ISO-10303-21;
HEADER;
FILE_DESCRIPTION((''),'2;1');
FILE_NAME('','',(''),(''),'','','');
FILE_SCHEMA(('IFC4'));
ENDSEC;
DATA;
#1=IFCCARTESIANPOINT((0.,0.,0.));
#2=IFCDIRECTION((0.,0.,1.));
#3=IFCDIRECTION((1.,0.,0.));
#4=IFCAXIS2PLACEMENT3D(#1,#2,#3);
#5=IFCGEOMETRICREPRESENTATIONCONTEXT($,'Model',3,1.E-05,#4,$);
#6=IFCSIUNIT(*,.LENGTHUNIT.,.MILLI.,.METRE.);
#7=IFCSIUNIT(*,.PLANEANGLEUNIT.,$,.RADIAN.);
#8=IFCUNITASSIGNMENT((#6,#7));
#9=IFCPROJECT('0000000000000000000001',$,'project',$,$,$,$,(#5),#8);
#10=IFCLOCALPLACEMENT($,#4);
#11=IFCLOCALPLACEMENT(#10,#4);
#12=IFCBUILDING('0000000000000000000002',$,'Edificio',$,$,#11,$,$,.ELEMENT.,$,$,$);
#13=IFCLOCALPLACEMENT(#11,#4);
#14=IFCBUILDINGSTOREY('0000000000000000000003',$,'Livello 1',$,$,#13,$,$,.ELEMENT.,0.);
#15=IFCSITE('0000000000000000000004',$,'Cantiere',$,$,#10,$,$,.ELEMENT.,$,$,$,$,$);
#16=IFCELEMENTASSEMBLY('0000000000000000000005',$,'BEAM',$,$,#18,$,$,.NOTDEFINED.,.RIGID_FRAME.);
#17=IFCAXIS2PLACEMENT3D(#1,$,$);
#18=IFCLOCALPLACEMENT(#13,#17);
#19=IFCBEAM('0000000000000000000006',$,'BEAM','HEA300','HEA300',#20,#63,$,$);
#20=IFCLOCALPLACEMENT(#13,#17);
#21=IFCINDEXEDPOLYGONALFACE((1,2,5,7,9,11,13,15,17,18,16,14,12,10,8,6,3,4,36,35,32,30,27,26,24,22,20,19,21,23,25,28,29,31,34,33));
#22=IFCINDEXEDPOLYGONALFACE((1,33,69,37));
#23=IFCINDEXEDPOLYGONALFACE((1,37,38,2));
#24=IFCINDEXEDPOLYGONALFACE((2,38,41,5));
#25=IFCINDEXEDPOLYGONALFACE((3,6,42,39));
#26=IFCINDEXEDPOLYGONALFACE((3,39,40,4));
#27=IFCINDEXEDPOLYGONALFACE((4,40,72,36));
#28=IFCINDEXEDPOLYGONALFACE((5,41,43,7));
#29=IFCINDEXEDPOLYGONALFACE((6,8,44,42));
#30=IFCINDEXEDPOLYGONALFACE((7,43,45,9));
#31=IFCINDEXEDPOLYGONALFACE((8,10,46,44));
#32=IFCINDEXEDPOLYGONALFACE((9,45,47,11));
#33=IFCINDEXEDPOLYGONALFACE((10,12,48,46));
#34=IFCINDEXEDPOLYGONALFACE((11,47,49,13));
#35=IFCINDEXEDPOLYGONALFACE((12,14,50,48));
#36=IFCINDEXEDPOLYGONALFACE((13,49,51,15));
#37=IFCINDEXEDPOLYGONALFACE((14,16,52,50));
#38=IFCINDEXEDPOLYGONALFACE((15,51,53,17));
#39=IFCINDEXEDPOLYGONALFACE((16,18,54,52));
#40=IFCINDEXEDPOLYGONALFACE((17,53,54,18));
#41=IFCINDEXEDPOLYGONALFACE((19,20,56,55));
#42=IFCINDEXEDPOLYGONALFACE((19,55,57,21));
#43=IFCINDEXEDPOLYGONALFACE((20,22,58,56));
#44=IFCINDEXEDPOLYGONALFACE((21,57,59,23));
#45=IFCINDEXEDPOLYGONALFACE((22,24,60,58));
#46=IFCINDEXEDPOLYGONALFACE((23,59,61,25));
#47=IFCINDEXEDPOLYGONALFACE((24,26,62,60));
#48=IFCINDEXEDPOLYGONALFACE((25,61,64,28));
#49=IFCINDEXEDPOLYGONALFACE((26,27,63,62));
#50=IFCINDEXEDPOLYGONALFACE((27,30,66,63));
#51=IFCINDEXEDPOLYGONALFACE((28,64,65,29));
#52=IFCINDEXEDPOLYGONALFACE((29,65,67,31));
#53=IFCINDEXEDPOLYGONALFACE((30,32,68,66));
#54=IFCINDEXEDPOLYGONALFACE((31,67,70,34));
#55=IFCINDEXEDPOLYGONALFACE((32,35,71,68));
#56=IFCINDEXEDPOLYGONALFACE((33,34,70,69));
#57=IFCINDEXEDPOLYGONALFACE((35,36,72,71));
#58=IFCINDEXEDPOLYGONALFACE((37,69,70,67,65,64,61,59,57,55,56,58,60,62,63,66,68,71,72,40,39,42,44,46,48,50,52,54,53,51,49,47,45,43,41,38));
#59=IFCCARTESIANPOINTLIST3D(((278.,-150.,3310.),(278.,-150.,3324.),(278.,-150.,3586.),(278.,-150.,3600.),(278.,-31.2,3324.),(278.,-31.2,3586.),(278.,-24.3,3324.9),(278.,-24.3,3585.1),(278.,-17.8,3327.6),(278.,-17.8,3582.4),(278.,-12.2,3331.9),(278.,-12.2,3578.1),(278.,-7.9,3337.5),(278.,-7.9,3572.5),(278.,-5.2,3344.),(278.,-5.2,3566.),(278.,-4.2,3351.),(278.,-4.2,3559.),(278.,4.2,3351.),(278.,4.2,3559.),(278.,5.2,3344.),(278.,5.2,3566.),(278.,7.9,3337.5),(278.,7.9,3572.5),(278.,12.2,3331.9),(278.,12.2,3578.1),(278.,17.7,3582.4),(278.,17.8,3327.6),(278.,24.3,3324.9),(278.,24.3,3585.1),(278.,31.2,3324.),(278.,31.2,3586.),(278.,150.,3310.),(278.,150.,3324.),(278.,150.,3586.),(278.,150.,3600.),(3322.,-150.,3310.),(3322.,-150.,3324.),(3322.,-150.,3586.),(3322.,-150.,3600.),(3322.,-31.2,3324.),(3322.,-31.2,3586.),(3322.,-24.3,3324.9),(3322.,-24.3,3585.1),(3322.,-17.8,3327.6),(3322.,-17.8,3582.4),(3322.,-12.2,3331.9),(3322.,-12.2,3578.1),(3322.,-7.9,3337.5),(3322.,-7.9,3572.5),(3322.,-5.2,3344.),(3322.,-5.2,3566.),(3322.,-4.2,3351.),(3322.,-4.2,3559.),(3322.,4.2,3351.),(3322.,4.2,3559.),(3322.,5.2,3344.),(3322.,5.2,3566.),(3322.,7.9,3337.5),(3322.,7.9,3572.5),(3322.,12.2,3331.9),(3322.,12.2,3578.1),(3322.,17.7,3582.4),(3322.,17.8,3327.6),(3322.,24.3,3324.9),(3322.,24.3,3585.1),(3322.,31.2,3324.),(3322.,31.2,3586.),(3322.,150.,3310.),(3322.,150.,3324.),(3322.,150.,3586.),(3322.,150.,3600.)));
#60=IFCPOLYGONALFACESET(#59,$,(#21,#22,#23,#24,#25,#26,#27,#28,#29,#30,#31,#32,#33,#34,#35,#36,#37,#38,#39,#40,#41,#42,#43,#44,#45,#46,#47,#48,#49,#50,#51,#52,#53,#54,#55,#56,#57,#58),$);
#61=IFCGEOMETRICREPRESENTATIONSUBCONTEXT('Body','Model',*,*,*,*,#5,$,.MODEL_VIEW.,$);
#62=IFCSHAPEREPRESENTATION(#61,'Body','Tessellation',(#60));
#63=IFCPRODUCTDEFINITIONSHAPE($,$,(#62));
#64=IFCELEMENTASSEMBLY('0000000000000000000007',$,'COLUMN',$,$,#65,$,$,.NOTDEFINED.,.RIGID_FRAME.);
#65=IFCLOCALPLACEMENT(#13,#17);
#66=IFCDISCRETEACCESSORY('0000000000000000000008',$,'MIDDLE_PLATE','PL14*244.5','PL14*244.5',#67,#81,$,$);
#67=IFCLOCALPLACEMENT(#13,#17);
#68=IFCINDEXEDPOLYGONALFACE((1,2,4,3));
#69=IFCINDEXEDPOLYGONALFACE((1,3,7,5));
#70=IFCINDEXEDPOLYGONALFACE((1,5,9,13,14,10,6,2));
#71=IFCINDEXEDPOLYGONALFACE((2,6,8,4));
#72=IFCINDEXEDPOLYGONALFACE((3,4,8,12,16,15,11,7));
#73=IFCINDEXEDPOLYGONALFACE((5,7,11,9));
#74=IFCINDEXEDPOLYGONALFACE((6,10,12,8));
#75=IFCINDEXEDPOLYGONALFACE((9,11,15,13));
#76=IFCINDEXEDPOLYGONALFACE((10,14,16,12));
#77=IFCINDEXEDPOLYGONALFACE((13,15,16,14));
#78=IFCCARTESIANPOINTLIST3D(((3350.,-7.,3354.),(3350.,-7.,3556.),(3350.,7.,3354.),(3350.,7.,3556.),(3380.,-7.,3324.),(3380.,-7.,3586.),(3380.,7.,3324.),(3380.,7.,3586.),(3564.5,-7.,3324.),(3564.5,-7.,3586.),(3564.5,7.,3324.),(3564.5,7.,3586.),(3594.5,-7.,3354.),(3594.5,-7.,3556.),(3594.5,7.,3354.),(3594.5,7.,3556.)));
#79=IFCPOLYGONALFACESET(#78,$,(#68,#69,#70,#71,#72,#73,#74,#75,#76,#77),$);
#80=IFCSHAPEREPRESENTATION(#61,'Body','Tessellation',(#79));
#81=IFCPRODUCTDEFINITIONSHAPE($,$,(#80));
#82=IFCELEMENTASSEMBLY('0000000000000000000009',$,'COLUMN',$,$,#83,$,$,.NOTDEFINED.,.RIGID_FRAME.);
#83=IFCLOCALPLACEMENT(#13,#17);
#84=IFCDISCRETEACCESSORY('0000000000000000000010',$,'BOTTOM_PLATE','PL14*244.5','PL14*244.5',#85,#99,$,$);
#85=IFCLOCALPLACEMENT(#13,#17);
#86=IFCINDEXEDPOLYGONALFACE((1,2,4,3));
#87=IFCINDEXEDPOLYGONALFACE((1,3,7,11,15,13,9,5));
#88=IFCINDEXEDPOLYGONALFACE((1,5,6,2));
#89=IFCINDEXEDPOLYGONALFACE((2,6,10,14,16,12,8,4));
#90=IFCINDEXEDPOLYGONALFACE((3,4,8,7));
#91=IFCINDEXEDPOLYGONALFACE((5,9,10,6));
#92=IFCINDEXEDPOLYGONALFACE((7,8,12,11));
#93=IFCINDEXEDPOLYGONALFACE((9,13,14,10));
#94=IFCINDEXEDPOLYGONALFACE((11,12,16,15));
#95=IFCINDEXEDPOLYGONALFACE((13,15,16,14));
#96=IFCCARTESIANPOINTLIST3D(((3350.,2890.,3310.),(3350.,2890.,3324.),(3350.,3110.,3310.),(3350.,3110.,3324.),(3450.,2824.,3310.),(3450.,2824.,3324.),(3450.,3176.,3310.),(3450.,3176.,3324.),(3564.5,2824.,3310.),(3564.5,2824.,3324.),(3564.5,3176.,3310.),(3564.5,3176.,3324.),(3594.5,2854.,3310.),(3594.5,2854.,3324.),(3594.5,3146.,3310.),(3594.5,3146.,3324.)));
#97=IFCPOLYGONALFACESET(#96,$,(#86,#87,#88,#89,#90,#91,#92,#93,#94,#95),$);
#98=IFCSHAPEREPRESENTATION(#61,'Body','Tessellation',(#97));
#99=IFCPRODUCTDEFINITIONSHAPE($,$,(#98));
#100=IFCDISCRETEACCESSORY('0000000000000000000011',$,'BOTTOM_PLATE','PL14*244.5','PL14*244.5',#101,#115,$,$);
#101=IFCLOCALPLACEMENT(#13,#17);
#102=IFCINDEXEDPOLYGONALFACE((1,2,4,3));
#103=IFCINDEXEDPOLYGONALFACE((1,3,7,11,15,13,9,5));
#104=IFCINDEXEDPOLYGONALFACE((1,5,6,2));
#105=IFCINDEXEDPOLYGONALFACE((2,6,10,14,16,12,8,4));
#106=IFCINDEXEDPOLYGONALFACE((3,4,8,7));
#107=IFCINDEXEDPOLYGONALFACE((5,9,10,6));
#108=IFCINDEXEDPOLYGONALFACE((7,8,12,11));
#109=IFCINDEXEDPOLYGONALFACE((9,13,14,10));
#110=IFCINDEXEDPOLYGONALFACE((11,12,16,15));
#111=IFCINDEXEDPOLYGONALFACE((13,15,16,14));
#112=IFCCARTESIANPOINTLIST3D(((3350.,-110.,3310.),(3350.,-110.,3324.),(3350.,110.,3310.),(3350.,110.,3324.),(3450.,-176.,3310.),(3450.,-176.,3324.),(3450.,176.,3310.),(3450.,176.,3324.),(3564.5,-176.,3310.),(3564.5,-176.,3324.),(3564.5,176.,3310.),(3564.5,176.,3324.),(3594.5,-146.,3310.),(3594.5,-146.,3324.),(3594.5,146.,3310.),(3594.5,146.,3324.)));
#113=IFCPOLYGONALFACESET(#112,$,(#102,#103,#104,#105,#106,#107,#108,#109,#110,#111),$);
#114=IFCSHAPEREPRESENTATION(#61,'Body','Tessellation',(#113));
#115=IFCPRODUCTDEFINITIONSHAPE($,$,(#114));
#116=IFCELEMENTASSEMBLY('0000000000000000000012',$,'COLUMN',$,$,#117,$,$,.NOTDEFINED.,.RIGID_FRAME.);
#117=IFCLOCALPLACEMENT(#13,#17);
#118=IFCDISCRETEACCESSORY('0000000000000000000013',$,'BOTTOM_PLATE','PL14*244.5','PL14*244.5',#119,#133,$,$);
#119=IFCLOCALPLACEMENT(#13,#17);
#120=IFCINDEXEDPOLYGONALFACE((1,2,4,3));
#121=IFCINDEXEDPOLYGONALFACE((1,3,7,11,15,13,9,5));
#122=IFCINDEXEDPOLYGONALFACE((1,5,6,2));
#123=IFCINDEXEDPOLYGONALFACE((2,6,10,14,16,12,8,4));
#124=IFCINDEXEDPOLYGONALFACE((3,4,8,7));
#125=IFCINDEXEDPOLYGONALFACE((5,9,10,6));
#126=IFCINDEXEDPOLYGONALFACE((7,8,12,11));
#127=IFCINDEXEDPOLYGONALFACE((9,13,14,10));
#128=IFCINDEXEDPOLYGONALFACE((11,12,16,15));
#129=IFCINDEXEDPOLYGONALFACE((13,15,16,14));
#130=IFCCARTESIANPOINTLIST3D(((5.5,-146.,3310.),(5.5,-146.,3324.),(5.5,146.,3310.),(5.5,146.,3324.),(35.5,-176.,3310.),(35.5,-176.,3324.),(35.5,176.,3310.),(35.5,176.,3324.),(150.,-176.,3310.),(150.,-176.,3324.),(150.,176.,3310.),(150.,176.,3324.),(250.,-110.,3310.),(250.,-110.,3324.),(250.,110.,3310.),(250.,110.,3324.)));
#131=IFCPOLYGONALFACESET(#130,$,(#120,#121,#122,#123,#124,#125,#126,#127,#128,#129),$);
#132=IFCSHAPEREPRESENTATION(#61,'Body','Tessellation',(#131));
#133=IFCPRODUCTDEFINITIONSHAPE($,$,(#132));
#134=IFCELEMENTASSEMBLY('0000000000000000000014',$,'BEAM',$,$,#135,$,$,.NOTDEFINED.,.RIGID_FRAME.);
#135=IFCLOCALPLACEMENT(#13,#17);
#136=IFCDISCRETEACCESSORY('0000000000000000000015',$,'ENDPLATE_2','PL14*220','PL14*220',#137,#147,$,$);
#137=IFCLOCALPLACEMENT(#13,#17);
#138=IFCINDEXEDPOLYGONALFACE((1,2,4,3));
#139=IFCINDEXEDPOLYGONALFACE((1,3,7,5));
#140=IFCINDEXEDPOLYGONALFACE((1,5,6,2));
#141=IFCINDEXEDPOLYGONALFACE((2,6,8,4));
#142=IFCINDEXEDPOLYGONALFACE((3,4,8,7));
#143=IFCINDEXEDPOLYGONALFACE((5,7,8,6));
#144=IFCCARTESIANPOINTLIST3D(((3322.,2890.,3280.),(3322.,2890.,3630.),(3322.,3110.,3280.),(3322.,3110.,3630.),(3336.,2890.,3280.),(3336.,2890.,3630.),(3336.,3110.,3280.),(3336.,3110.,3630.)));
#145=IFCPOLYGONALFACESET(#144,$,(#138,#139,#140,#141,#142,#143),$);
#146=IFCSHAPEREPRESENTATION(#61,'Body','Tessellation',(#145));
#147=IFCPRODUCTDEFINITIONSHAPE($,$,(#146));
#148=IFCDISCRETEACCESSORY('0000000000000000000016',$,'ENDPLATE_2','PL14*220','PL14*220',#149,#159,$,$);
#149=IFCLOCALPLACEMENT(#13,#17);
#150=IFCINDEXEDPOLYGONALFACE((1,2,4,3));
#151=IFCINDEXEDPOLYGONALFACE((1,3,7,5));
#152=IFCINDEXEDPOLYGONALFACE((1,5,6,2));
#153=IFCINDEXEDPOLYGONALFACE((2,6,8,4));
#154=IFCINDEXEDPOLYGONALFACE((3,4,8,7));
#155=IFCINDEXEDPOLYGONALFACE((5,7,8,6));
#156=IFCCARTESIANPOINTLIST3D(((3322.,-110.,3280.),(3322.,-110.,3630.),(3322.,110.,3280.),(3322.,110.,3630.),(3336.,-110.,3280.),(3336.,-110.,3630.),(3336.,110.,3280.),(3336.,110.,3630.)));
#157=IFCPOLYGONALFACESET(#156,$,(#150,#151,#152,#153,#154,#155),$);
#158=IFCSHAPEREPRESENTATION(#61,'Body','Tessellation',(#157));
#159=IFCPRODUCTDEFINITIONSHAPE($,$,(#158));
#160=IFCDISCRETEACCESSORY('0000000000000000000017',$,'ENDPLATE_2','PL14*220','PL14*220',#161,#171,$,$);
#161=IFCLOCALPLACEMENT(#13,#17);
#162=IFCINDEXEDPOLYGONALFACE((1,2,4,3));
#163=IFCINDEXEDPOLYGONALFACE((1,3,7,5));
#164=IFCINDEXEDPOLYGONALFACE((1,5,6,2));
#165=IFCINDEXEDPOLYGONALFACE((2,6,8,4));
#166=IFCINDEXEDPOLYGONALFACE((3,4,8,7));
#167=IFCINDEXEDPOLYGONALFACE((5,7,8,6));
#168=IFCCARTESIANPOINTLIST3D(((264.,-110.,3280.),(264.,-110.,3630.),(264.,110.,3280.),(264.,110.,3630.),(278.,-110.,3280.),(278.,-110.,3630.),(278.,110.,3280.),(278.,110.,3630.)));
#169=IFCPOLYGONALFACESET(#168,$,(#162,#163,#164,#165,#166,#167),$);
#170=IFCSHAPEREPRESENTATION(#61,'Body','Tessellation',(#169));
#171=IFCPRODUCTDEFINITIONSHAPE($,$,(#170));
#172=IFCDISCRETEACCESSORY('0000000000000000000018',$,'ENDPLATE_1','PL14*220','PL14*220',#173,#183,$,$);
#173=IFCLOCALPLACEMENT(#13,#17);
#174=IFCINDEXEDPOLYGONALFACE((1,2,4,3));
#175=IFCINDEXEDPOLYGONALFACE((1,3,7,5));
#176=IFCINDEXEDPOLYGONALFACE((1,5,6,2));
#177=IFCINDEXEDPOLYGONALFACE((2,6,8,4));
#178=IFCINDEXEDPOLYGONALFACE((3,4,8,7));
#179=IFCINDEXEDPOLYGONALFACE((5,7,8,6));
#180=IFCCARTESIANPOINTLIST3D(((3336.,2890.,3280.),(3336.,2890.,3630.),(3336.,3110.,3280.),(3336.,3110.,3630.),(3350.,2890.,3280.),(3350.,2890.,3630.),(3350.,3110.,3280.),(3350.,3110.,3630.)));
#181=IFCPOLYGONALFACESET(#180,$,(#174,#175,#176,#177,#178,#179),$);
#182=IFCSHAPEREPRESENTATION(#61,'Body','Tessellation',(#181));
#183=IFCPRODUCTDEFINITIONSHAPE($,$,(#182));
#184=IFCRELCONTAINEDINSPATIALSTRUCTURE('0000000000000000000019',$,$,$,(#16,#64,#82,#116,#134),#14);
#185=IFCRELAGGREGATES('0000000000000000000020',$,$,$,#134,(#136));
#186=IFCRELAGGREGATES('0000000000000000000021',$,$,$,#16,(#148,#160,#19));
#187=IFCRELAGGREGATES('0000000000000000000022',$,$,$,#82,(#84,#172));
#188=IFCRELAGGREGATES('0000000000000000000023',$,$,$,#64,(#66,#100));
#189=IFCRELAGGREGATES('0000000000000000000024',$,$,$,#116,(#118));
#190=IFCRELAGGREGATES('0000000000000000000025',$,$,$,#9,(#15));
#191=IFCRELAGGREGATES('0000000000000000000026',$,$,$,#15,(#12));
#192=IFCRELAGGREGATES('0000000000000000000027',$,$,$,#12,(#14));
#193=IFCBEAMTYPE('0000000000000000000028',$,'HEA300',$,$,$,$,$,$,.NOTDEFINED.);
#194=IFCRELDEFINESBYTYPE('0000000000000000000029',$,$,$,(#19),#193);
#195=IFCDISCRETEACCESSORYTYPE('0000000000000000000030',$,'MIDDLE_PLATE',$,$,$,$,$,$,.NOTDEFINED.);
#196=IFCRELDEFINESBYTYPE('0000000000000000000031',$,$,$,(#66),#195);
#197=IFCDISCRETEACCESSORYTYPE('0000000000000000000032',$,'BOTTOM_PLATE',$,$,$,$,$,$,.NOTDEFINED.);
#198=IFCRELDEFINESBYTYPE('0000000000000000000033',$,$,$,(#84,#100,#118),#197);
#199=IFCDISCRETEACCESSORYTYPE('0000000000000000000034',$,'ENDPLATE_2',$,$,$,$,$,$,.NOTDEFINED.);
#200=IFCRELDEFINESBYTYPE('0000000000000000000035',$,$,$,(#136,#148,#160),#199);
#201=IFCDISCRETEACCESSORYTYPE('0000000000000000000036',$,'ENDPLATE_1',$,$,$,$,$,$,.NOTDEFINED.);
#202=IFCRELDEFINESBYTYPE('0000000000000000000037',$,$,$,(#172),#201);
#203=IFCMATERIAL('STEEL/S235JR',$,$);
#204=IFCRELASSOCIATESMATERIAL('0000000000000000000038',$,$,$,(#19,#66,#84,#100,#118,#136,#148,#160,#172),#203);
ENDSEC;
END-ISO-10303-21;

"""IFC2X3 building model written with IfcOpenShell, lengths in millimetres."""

from ifc_helpers import new_model, si_unit, frame, origin_with_axes, origin_2d_with_axis, place, context, subcontext, project, spatial, polyline, i_section, outline, extrude, clip, halfspace, material, type_object, element, aggregate, save


model = new_model("IFC2X3")

# Units and contexts
model_context = context("Model", 3, precision=1e-05, world=origin_with_axes())
body_context = subcontext(model_context, "Body", "Model", "MODEL_VIEW")
ifc_project = project(units=[si_unit("LENGTHUNIT", "METRE", prefix="MILLI"), si_unit("PLANEANGLEUNIT", "RADIAN")], contexts=[model_context])

# Site, building, storey
site_placement = place(None, origin_with_axes())
site = spatial("IfcSite", under=ifc_project, at=site_placement, Name="Cantiere", CompositionType="ELEMENT")
building_placement = place(site_placement, origin_with_axes())
building = spatial("IfcBuilding", under=site, at=building_placement, Name="Edificio", CompositionType="ELEMENT")
storey_placement = place(building_placement, origin_with_axes())
storey = spatial("IfcBuildingStorey", under=building, at=storey_placement, Name="Livello 1", CompositionType="ELEMENT", Elevation=0.0)

# Element assembly, beam
assembly_1_placement = place(storey_placement, origin_with_axes())
assembly_1 = element("IfcElementAssembly", 1, at=assembly_1_placement, inside=storey, Name="BEAM", AssemblyPlace="NOTDEFINED", PredefinedType="RIGID_FRAME")
ifc_material_1 = material(Name="STEEL/S235JR")
beam_type = type_object("IfcBeamType", Name="HEA300", PredefinedType="NOTDEFINED")
beam_placement = place(assembly_1_placement, frame((0.0, 0.0, 3455.0), z_axis=(0.0, 0.0, 1.0), x_axis=(1.0, 0.0, 0.0)))
beam = element("IfcBeam", 2, at=beam_placement, type_object=beam_type, material=ifc_material_1, Name="BEAM", Description="HEA300", ObjectType="HEA300", context=body_context, shape_type="Clipping", body=[
    clip(clip(extrude(i_section(OverallWidth=300.0, OverallDepth=290.0, WebThickness=8.5, FlangeThickness=14.0, FilletRadius=27.0, at=origin_2d_with_axis()), frame((3322.0, 0.0, 0.0), z_axis=(-1.0, 0.0, 0.0), x_axis=(0.0, -1.0, 0.0)), (0.0, 0.0, 1.0), 3044.0), halfspace(frame((3322.0, -150.0, 0.0), z_axis=(1.0, 0.0, 0.0), x_axis=(0.0, 0.0, 1.0)), False)), halfspace(frame((278.0, 150.0, 0.0), z_axis=(-1.0, 0.0, 0.0), x_axis=(0.0, 0.0, 1.0)), False)),
])

# Element assemblies, discrete accessories
assembly_2_placement = place(storey_placement, origin_with_axes())
assembly_2 = element("IfcElementAssembly", 3, at=assembly_2_placement, inside=storey, Name="COLUMN", AssemblyPlace="NOTDEFINED", PredefinedType="RIGID_FRAME")
discrete_accessory_type_1 = type_object("IfcDiscreteAccessoryType", Name="MIDDLE_PLATE")
discrete_accessory_1_placement = place(assembly_2_placement, frame((3350.0, 0.0, 3586.0), z_axis=(0.0, 1.0, 0.0), x_axis=(1.0, 0.0, 0.0)))
discrete_accessory_1 = element("IfcDiscreteAccessory", 4, at=discrete_accessory_1_placement, type_object=discrete_accessory_type_1, material=ifc_material_1, Name="MIDDLE_PLATE", Description="PL14*244.5", ObjectType="PL14*244.5", context=body_context, shape_type="SweptSolid", body=[
    extrude(outline(polyline([(0.0, 30.0), (30.0, 0.0), (214.5, 0.0), (244.5, 30.0), (244.5, 232.0), (214.5, 262.0), (30.0, 262.0), (0.0, 232.0), (0.0, 30.0)])), frame((0.0, 0.0, -7.0), z_axis=(0.0, 0.0, 1.0), x_axis=(1.0, 0.0, 0.0)), (0.0, 0.0, 1.0), 14.0),
])
assembly_3_placement = place(storey_placement, origin_with_axes())
assembly_3 = element("IfcElementAssembly", 5, at=assembly_3_placement, inside=storey, Name="COLUMN", AssemblyPlace="NOTDEFINED", PredefinedType="RIGID_FRAME")
discrete_accessory_type_2 = type_object("IfcDiscreteAccessoryType", Name="BOTTOM_PLATE")
discrete_accessory_2_placement = place(assembly_3_placement, frame((3594.5, 2824.0, 3317.0), z_axis=(0.0, 0.0, 1.0), x_axis=(0.0, 1.0, 0.0)))
discrete_accessory_2 = element("IfcDiscreteAccessory", 6, at=discrete_accessory_2_placement, type_object=discrete_accessory_type_2, material=ifc_material_1, Name="BOTTOM_PLATE", Description="PL14*244.5", ObjectType="PL14*244.5", context=body_context, shape_type="SweptSolid", body=[
    extrude(outline(polyline([(0.0, 30.0), (30.0, 0.0), (322.0, 0.0), (352.0, 30.0), (352.0, 144.5), (286.0, 244.5), (66.0, 244.5), (0.0, 144.5), (0.0, 30.0)])), frame((0.0, 0.0, -7.0), z_axis=(0.0, 0.0, 1.0), x_axis=(1.0, 0.0, 0.0)), (0.0, 0.0, 1.0), 14.0),
])

# Discrete accessory
discrete_accessory_3_placement = place(assembly_2_placement, frame((3594.5, -176.0, 3317.0), z_axis=(0.0, 0.0, 1.0), x_axis=(0.0, 1.0, 0.0)))
discrete_accessory_3 = element("IfcDiscreteAccessory", 7, at=discrete_accessory_3_placement, type_object=discrete_accessory_type_2, material=ifc_material_1, Name="BOTTOM_PLATE", Description="PL14*244.5", ObjectType="PL14*244.5", context=body_context, shape_type="SweptSolid", body=[
    extrude(outline(polyline([(0.0, 30.0), (30.0, 0.0), (322.0, 0.0), (352.0, 30.0), (352.0, 144.5), (286.0, 244.5), (66.0, 244.5), (0.0, 144.5), (0.0, 30.0)])), frame((0.0, 0.0, -7.0), z_axis=(0.0, 0.0, 1.0), x_axis=(1.0, 0.0, 0.0)), (0.0, 0.0, 1.0), 14.0),
])

# Element assemblies, discrete accessories
assembly_4_placement = place(storey_placement, origin_with_axes())
assembly_4 = element("IfcElementAssembly", 8, at=assembly_4_placement, inside=storey, Name="COLUMN", AssemblyPlace="NOTDEFINED", PredefinedType="RIGID_FRAME")
discrete_accessory_4_placement = place(assembly_4_placement, frame((5.5, 176.0, 3317.0), z_axis=(0.0, 0.0, 1.0), x_axis=(0.0, -1.0, 0.0)))
discrete_accessory_4 = element("IfcDiscreteAccessory", 9, at=discrete_accessory_4_placement, type_object=discrete_accessory_type_2, material=ifc_material_1, Name="BOTTOM_PLATE", Description="PL14*244.5", ObjectType="PL14*244.5", context=body_context, shape_type="SweptSolid", body=[
    extrude(outline(polyline([(0.0, 30.0), (30.0, 0.0), (322.0, 0.0), (352.0, 30.0), (352.0, 144.5), (286.0, 244.5), (66.0, 244.5), (0.0, 144.5), (0.0, 30.0)])), frame((0.0, 0.0, -7.0), z_axis=(0.0, 0.0, 1.0), x_axis=(1.0, 0.0, 0.0)), (0.0, 0.0, 1.0), 14.0),
])
assembly_5_placement = place(storey_placement, origin_with_axes())
assembly_5 = element("IfcElementAssembly", 10, at=assembly_5_placement, inside=storey, Name="BEAM", AssemblyPlace="NOTDEFINED", PredefinedType="RIGID_FRAME")
discrete_accessory_type_3 = type_object("IfcDiscreteAccessoryType", Name="ENDPLATE_2")
discrete_accessory_5_placement = place(assembly_5_placement, frame((3329.0, 2890.0, 3280.0), z_axis=(-1.0, 0.0, 0.0), x_axis=(0.0, 0.0, 1.0)))
discrete_accessory_5 = element("IfcDiscreteAccessory", 11, at=discrete_accessory_5_placement, type_object=discrete_accessory_type_3, material=ifc_material_1, Name="ENDPLATE_2", Description="PL14*220", ObjectType="PL14*220", context=body_context, shape_type="SweptSolid", body=[
    extrude(outline(polyline([(0.0, 0.0), (350.0, 0.0), (350.0, 220.0), (0.0, 220.0), (0.0, 0.0)])), frame((0.0, 0.0, -7.0), z_axis=(0.0, 0.0, 1.0), x_axis=(1.0, 0.0, 0.0)), (0.0, 0.0, 1.0), 14.0),
])
aggregate(assembly_5, [discrete_accessory_5])

# Discrete accessories
discrete_accessory_6_placement = place(assembly_1_placement, frame((3329.0, -110.0, 3280.0), z_axis=(-1.0, 0.0, 0.0), x_axis=(0.0, 0.0, 1.0)))
discrete_accessory_6 = element("IfcDiscreteAccessory", 12, at=discrete_accessory_6_placement, type_object=discrete_accessory_type_3, material=ifc_material_1, Name="ENDPLATE_2", Description="PL14*220", ObjectType="PL14*220", context=body_context, shape_type="SweptSolid", body=[
    extrude(outline(polyline([(0.0, 0.0), (350.0, 0.0), (350.0, 220.0), (0.0, 220.0), (0.0, 0.0)])), frame((0.0, 0.0, -7.0), z_axis=(0.0, 0.0, 1.0), x_axis=(1.0, 0.0, 0.0)), (0.0, 0.0, 1.0), 14.0),
])
discrete_accessory_7_placement = place(assembly_1_placement, frame((271.0, 110.0, 3280.0), z_axis=(1.0, 0.0, 0.0), x_axis=(0.0, 0.0, 1.0)))
discrete_accessory_7 = element("IfcDiscreteAccessory", 13, at=discrete_accessory_7_placement, type_object=discrete_accessory_type_3, material=ifc_material_1, Name="ENDPLATE_2", Description="PL14*220", ObjectType="PL14*220", context=body_context, shape_type="SweptSolid", body=[
    extrude(outline(polyline([(0.0, 0.0), (350.0, 0.0), (350.0, 220.0), (0.0, 220.0), (0.0, 0.0)])), frame((0.0, 0.0, -7.0), z_axis=(0.0, 0.0, 1.0), x_axis=(1.0, 0.0, 0.0)), (0.0, 0.0, 1.0), 14.0),
])
aggregate(assembly_1, [discrete_accessory_6, discrete_accessory_7, beam])
discrete_accessory_type_4 = type_object("IfcDiscreteAccessoryType", Name="ENDPLATE_1")
discrete_accessory_8_placement = place(assembly_3_placement, frame((3343.0, 2890.0, 3280.0), z_axis=(-1.0, 0.0, 0.0), x_axis=(0.0, 0.0, 1.0)))
discrete_accessory_8 = element("IfcDiscreteAccessory", 14, at=discrete_accessory_8_placement, type_object=discrete_accessory_type_4, material=ifc_material_1, Name="ENDPLATE_1", Description="PL14*220", ObjectType="PL14*220", context=body_context, shape_type="SweptSolid", body=[
    extrude(outline(polyline([(0.0, 0.0), (350.0, 0.0), (350.0, 220.0), (0.0, 220.0), (0.0, 0.0)])), frame((0.0, 0.0, -7.0), z_axis=(0.0, 0.0, 1.0), x_axis=(1.0, 0.0, 0.0)), (0.0, 0.0, 1.0), 14.0),
])
aggregate(assembly_3, [discrete_accessory_2, discrete_accessory_8])
aggregate(assembly_2, [discrete_accessory_1, discrete_accessory_3])
aggregate(assembly_4, [discrete_accessory_4])

save(model, "model.ifc")
